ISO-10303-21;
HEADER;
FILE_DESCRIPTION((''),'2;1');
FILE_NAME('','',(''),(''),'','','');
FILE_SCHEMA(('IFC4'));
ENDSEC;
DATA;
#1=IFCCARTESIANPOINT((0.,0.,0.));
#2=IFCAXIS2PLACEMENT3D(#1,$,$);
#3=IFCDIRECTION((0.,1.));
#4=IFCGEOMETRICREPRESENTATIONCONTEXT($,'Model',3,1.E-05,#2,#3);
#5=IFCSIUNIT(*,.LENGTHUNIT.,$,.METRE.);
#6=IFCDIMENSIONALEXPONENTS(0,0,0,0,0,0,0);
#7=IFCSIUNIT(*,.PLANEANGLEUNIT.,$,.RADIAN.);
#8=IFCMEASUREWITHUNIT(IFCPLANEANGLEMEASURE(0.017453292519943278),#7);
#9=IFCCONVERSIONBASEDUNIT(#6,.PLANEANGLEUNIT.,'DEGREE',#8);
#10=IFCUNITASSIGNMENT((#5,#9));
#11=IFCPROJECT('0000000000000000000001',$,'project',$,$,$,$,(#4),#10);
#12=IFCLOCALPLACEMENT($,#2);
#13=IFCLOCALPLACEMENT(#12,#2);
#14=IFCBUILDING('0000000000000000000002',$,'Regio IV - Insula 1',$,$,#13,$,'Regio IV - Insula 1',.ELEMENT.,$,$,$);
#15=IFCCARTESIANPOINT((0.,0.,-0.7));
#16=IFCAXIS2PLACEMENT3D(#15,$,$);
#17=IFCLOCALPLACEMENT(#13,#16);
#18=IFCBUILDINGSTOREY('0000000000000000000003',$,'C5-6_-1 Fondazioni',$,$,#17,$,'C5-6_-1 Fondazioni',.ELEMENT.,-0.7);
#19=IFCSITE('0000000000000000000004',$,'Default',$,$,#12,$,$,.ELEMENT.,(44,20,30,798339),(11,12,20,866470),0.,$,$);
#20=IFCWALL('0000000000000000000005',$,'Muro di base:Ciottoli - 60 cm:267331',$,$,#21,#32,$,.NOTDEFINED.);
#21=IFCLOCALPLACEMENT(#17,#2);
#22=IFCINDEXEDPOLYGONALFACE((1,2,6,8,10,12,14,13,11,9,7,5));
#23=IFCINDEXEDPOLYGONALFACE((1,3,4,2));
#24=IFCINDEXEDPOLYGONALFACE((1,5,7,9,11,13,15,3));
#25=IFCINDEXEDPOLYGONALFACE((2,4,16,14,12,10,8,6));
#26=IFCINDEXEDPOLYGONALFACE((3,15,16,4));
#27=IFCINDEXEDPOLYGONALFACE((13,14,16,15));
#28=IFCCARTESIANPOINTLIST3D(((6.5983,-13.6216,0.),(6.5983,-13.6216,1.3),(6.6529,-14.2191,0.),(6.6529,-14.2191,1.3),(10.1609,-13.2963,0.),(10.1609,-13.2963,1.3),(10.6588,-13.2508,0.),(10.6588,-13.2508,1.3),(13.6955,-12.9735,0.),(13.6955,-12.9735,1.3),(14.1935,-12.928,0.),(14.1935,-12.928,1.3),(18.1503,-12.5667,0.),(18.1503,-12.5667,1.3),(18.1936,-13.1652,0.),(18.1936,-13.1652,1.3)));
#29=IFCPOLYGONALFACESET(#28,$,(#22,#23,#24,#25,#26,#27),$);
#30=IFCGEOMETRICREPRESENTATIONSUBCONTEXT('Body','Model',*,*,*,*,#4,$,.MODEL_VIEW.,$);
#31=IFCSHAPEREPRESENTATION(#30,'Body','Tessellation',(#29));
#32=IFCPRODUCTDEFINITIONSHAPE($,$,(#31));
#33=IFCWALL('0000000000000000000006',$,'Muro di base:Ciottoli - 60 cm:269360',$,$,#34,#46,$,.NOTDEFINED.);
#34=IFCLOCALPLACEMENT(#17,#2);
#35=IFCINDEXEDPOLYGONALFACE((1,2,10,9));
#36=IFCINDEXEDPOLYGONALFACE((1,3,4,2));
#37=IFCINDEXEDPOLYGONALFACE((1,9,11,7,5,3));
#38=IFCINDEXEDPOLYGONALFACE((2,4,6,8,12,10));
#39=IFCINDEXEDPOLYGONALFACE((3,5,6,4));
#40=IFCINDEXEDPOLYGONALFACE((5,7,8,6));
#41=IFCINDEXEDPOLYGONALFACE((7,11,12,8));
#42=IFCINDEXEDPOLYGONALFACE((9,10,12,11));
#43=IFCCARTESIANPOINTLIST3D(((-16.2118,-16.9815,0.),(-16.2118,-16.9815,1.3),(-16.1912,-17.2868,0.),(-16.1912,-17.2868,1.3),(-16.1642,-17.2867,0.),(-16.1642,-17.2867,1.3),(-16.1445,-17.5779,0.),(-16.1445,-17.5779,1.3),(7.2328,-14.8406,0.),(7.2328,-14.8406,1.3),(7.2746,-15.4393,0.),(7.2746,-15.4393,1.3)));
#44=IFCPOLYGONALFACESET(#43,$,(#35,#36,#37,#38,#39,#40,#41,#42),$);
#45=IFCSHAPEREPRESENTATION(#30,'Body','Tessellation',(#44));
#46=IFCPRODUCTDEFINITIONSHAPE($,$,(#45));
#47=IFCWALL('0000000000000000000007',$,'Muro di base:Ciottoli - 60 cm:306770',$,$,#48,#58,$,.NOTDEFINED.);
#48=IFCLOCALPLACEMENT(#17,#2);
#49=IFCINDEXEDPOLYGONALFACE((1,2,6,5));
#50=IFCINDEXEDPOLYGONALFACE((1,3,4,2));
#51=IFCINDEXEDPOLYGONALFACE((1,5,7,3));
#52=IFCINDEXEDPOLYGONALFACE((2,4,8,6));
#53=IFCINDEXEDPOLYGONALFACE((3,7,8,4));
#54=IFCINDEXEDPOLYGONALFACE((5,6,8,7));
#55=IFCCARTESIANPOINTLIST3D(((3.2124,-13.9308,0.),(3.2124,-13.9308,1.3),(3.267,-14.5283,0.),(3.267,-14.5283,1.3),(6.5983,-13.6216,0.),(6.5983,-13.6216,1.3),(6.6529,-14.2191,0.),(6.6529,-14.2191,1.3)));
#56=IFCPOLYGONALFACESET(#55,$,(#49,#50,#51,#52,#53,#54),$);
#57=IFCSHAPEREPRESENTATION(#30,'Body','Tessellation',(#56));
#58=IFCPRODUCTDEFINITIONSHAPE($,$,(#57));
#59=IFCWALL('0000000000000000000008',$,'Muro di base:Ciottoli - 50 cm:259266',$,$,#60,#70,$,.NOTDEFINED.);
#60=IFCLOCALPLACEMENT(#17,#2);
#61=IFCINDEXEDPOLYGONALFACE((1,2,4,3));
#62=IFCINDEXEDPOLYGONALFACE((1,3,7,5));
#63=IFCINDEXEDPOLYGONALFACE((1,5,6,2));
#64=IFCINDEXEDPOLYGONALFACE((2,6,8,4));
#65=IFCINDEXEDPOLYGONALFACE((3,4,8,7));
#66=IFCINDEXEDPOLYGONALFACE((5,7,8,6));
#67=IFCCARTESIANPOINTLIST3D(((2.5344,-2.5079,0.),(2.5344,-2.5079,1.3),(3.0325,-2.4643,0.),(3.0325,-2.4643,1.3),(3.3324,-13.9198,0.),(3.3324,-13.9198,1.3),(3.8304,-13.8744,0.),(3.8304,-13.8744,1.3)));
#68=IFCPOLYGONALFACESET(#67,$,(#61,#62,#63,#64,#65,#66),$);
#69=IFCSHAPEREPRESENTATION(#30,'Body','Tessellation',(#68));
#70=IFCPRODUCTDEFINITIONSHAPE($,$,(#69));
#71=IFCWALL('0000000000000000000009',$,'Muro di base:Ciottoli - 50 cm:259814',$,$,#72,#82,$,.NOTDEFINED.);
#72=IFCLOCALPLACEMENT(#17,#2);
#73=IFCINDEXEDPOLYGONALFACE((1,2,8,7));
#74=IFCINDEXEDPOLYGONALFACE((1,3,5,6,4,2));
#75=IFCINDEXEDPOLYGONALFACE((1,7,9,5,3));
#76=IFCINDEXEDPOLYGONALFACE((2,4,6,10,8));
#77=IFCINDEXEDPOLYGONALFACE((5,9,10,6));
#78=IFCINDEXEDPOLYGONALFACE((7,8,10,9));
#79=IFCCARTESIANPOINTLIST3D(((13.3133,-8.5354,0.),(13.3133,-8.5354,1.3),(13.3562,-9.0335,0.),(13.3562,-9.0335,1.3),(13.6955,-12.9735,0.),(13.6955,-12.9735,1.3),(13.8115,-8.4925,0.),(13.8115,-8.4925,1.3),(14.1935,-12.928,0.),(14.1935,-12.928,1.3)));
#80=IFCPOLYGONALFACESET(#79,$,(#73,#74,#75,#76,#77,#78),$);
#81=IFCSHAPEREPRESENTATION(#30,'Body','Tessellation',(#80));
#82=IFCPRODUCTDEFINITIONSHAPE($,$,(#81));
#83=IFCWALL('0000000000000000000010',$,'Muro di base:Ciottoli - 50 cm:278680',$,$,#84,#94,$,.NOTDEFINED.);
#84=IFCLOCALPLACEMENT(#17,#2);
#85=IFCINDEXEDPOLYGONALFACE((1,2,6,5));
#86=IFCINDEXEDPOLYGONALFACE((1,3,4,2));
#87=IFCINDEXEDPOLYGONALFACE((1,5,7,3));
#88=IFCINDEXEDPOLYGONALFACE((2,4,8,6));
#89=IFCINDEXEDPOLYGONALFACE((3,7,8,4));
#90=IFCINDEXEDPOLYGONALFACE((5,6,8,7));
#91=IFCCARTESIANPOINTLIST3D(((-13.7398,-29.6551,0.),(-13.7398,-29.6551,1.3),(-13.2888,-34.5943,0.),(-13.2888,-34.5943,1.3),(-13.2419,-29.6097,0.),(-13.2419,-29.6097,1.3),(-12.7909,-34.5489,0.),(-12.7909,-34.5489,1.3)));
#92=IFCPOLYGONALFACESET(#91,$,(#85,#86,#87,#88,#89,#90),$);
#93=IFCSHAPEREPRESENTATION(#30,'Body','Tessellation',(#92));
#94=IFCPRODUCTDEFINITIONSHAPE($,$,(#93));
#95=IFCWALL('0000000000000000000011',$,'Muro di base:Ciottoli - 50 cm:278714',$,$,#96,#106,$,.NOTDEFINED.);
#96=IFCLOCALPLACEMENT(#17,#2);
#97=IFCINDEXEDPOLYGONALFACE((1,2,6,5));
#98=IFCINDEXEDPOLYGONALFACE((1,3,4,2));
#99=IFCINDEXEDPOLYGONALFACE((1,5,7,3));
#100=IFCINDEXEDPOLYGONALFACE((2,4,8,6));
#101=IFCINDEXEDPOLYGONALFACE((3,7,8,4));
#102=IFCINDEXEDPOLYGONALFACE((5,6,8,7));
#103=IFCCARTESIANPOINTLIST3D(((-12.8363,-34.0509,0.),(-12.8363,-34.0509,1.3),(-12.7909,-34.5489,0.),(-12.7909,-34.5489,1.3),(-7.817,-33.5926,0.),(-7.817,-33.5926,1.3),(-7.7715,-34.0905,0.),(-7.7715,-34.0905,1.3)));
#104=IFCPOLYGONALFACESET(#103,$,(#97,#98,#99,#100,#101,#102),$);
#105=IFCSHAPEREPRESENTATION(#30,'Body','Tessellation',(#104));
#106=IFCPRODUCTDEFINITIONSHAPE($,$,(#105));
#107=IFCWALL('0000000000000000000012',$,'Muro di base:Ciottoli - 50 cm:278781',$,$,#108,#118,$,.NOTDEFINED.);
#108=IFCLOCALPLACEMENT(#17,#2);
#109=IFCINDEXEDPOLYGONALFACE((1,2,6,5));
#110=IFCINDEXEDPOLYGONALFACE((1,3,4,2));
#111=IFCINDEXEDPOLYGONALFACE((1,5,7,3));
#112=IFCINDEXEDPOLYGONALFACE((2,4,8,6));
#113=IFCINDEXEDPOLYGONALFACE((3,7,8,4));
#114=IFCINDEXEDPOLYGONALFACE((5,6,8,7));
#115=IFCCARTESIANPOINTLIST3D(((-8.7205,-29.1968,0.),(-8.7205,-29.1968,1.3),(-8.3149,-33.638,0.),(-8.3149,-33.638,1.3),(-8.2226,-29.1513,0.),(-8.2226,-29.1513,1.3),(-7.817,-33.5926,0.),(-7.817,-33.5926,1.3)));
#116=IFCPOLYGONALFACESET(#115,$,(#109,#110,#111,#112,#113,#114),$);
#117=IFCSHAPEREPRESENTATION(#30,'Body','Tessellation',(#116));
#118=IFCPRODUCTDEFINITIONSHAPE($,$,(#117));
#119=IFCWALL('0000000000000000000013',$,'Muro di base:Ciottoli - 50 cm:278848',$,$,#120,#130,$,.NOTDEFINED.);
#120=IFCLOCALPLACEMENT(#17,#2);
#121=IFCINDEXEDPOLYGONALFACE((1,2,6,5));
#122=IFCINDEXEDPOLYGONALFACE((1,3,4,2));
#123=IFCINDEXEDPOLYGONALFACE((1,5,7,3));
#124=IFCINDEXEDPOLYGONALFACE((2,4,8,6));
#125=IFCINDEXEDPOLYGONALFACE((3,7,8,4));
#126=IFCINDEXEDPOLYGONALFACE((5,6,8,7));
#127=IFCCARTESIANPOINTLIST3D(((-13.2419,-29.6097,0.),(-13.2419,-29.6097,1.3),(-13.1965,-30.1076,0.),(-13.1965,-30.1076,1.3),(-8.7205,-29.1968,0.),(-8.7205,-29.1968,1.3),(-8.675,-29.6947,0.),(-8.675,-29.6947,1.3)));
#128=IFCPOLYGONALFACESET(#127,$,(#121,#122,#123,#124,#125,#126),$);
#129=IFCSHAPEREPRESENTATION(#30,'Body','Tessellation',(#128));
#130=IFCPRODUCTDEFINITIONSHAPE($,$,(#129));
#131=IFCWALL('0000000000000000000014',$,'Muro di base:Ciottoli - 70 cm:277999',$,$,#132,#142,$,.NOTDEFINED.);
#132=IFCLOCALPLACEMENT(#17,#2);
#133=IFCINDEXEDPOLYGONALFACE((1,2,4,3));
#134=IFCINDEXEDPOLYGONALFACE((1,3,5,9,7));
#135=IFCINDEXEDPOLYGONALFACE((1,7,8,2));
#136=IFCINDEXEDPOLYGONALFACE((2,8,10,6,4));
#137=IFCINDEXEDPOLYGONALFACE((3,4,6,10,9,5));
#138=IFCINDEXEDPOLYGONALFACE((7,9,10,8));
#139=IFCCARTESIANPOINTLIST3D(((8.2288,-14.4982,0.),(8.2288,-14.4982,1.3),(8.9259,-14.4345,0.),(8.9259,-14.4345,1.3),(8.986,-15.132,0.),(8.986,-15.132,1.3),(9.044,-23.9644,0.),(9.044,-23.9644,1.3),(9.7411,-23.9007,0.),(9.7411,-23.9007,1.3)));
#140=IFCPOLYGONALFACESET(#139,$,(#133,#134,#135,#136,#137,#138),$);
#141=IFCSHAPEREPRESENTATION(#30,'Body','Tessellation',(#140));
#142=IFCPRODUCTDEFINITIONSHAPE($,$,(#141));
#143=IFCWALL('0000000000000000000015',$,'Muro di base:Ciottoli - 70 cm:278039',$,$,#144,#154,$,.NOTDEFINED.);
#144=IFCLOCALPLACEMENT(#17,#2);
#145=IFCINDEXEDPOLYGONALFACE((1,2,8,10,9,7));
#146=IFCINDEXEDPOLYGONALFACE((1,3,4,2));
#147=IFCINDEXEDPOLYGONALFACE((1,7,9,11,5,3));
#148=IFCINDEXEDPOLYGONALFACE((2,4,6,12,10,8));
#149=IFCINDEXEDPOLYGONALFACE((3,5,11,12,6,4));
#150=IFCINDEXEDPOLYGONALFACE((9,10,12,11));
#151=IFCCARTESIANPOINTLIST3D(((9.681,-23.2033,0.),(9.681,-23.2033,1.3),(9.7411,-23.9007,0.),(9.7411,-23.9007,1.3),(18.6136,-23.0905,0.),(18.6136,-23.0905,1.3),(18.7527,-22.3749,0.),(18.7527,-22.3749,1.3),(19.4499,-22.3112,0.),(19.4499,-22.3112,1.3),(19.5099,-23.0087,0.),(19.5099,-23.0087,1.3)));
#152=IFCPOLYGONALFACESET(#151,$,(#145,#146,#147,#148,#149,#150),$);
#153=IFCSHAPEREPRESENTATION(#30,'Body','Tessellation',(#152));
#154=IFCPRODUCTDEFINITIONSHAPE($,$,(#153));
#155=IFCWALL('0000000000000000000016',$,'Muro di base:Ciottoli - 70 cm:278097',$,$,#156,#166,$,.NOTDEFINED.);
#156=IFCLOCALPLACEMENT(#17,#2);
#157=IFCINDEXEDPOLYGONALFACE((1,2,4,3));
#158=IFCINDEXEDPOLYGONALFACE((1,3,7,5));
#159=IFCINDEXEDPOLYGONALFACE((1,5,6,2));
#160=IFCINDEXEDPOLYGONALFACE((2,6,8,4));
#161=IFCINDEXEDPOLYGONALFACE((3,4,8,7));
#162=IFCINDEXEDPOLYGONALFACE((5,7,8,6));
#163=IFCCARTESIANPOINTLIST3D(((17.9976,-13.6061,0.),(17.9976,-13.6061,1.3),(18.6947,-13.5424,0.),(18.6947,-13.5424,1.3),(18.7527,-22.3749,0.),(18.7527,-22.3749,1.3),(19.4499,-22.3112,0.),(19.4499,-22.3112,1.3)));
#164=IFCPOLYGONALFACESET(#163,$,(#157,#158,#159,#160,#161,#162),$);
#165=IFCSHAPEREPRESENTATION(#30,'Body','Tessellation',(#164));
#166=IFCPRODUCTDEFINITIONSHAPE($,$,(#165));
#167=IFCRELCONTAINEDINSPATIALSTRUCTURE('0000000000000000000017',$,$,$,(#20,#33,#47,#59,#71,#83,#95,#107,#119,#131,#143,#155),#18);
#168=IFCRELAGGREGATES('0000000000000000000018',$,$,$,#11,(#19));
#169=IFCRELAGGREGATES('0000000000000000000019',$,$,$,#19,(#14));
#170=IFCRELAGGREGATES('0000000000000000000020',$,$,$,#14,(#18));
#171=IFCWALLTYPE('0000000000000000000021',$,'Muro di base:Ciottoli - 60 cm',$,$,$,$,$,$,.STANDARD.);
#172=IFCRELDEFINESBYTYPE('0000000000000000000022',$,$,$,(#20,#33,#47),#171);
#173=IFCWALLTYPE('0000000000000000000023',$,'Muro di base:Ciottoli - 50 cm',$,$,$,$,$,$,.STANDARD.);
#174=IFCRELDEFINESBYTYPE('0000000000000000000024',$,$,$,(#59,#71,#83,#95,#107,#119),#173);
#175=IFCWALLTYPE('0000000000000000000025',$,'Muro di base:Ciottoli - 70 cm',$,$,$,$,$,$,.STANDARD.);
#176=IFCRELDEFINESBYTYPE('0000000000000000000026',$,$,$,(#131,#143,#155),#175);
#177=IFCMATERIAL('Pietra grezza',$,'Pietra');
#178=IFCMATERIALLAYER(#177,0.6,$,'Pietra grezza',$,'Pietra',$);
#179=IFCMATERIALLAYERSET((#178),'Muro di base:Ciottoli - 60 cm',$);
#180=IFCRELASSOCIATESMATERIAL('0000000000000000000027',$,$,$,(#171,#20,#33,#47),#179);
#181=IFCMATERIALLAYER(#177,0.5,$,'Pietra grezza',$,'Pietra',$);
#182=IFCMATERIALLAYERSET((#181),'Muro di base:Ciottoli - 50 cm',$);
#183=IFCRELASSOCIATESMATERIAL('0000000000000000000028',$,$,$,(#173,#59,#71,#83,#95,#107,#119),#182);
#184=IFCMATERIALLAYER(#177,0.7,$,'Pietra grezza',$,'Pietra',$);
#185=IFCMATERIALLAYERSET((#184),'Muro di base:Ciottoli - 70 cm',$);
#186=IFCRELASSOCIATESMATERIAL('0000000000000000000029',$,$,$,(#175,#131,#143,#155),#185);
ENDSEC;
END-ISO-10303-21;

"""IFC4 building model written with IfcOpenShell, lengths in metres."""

from ifc_helpers import new_model, entity, si_unit, converted_unit, direction, frame, frame_2d, origin, place, context, subcontext, project, spatial, polyline, rectangle, outline, extrude, material, layer, layer_set, layer_usage, type_object, element, save


model = new_model("IFC4")

# Units and contexts
model_context = context("Model", 3, precision=1e-05, world=origin(), true_north=direction((0.0, 1.0)))
body_context = subcontext(model_context, "Body", "Model", "MODEL_VIEW")
ifc_project = project(units=[si_unit("LENGTHUNIT", "METRE"), converted_unit("PLANEANGLEUNIT", "DEGREE", entity("IfcPlaneAngleMeasure", 0.017453292519943278), si_unit("PLANEANGLEUNIT", "RADIAN"), dimensions=[0, 0, 0, 0, 0, 0, 0])], contexts=[model_context])

# Site, building, storey
site_placement = place(None, origin())
site = spatial("IfcSite", under=ifc_project, at=site_placement, Name="Default", CompositionType="ELEMENT", RefLatitude=(44, 20, 30, 798339), RefLongitude=(11, 12, 20, 866470), RefElevation=0.0)
building_placement = place(site_placement, origin())
building = spatial("IfcBuilding", under=site, at=building_placement, Name="Regio IV - Insula 1", LongName="Regio IV - Insula 1", CompositionType="ELEMENT")
storey_placement = place(building_placement, frame((0.0, 0.0, -0.7)))
storey = spatial("IfcBuildingStorey", under=building, at=storey_placement, Name="C5-6_-1 Fondazioni", LongName="C5-6_-1 Fondazioni", CompositionType="ELEMENT", Elevation=-0.7)

# Walls
ifc_material = material(Name="Pietra grezza", Category="Pietra")
ifc_layer_1 = layer(ifc_material, 0.6, Name="Pietra grezza", Category="Pietra")
ifc_layer_set_1 = layer_set([ifc_layer_1], Name="Muro di base:Ciottoli - 60 cm")
ifc_layer_usage_1 = layer_usage(ifc_layer_set_1, "AXIS2", "NEGATIVE", 0.3)
wall_type_1 = type_object("IfcWallType", Name="Muro di base:Ciottoli - 60 cm", PredefinedType="STANDARD", material=ifc_layer_set_1)
wall_1_placement = place(storey_placement, frame((6.6256, -13.9203, 0.0), z_axis=(0.0, 0.0, 1.0), x_axis=(0.995856, 0.090941, 0.0)))
element("IfcWall", 1, at=wall_1_placement, inside=storey, type_object=wall_type_1, material=ifc_layer_usage_1, Name="Muro di base:Ciottoli - 60 cm:267331", PredefinedType="NOTDEFINED", context=body_context, shape_type="SweptSolid", body=[
    extrude(outline(polyline([(11.5887, -0.3), (11.6, 0.3), (7.6267, 0.3), (7.1267, 0.3), (4.0774, 0.3), (3.5774, 0.3), (0.0, 0.3), (0.0, -0.3), (11.5887, -0.3)])), origin(), (0.0, 0.0, 1.0), 1.3),
])
ifc_layer_usage_2 = layer_usage(ifc_layer_set_1, "AXIS2", "NEGATIVE", 0.3)
wall_2_placement = place(storey_placement, frame((-16.1845, -17.2803, 0.0), z_axis=(0.0, 0.0, 1.0), x_axis=(0.995856, 0.090941, 0.0)))
element("IfcWall", 2, at=wall_2_placement, inside=storey, type_object=wall_type_1, material=ifc_layer_usage_2, Name="Muro di base:Ciottoli - 60 cm:269360", PredefinedType="NOTDEFINED", context=body_context, shape_type="SweptSolid", body=[
    extrude(outline(polyline([(23.5294, -0.3), (23.5421, 0.3), (0.0, 0.3), (-0.0072, -0.0059), (0.0197, -0.0082), (0.0128, -0.3), (23.5294, -0.3)])), origin(), (0.0, 0.0, 1.0), 1.3),
])
ifc_layer_usage_3 = layer_usage(ifc_layer_set_1, "AXIS2", "NEGATIVE", 0.3)
wall_3_placement = place(storey_placement, frame((3.2397, -14.2295, 0.0), z_axis=(0.0, 0.0, 1.0), x_axis=(0.995856, 0.090941, 0.0)))
element("IfcWall", 3, at=wall_3_placement, inside=storey, type_object=wall_type_1, material=ifc_layer_usage_3, Name="Muro di base:Ciottoli - 60 cm:306770", PredefinedType="NOTDEFINED", context=body_context, shape_type="SweptSolid", body=[
    extrude(rectangle(XDim=3.4, YDim=0.6, at=frame_2d((1.7, 0.0), x_axis=(-1.0, 0.0))), origin(), (0.0, 0.0, 1.0), 1.3),
])
ifc_layer_2 = layer(ifc_material, 0.5, Name="Pietra grezza", Category="Pietra")
ifc_layer_set_2 = layer_set([ifc_layer_2], Name="Muro di base:Ciottoli - 50 cm")
ifc_layer_usage_4 = layer_usage(ifc_layer_set_2, "AXIS2", "NEGATIVE", 0.25)
wall_type_2 = type_object("IfcWallType", Name="Muro di base:Ciottoli - 50 cm", PredefinedType="STANDARD", material=ifc_layer_set_2)
wall_4_placement = place(storey_placement, frame((3.5818, -13.9024, 0.0), z_axis=(0.0, 0.0, 1.0), x_axis=(-0.069756, 0.997564, 0.0)))
element("IfcWall", 4, at=wall_4_placement, inside=storey, type_object=wall_type_2, material=ifc_layer_usage_4, Name="Muro di base:Ciottoli - 50 cm:259266", PredefinedType="NOTDEFINED", context=body_context, shape_type="SweptSolid", body=[
    extrude(outline(polyline([(11.4486, -0.25), (11.4398, 0.25), (0.0, 0.25), (0.0106, -0.25), (11.4486, -0.25)])), origin(), (0.0, 0.0, 1.0), 1.3),
])
ifc_layer_usage_5 = layer_usage(ifc_layer_set_2, "AXIS2", "NEGATIVE", 0.25)
wall_5_placement = place(storey_placement, frame((13.9446, -12.952, 0.0), z_axis=(0.0, 0.0, 1.0), x_axis=(-0.085801, 0.996312, 0.0)))
element("IfcWall", 5, at=wall_5_placement, inside=storey, type_object=wall_type_2, material=ifc_layer_usage_5, Name="Muro di base:Ciottoli - 50 cm:259814", PredefinedType="NOTDEFINED", context=body_context, shape_type="SweptSolid", body=[
    extrude(outline(polyline([(4.4545, -0.25), (4.4545, 0.25), (3.9545, 0.25), (0.0, 0.25), (0.0026, -0.25), (4.4545, -0.25)])), origin(), (0.0, 0.0, 1.0), 1.3),
])
ifc_layer_usage_6 = layer_usage(ifc_layer_set_2, "AXIS2", "NEGATIVE", 0.25)
wall_6_placement = place(storey_placement, frame((-13.4909, -29.6324, 0.0), z_axis=(0.0, 0.0, 1.0), x_axis=(0.090941, -0.995856, 0.0)))
element("IfcWall", 6, at=wall_6_placement, inside=storey, type_object=wall_type_2, material=ifc_layer_usage_6, Name="Muro di base:Ciottoli - 50 cm:278680", PredefinedType="NOTDEFINED", context=body_context, shape_type="SweptSolid", body=[
    extrude(rectangle(XDim=4.9598, YDim=0.5, at=frame_2d((2.4799, 0.0), x_axis=(-1.0, 0.0))), origin(), (0.0, 0.0, 1.0), 1.3),
])
ifc_layer_usage_7 = layer_usage(ifc_layer_set_2, "AXIS2", "NEGATIVE", 0.25)
wall_7_placement = place(storey_placement, frame((-12.8136, -34.2999, 0.0), z_axis=(0.0, 0.0, 1.0), x_axis=(0.995856, 0.090941, 0.0)))
element("IfcWall", 7, at=wall_7_placement, inside=storey, type_object=wall_type_2, material=ifc_layer_usage_7, Name="Muro di base:Ciottoli - 50 cm:278714", PredefinedType="NOTDEFINED", context=body_context, shape_type="SweptSolid", body=[
    extrude(rectangle(XDim=5.0402, YDim=0.5, at=frame_2d((2.5201, 0.0), x_axis=(-1.0, 0.0))), origin(), (0.0, 0.0, 1.0), 1.3),
])
ifc_layer_usage_8 = layer_usage(ifc_layer_set_2, "AXIS2", "NEGATIVE", 0.25)
wall_8_placement = place(storey_placement, frame((-8.0659, -33.6153, 0.0), z_axis=(0.0, 0.0, 1.0), x_axis=(-0.090941, 0.995856, 0.0)))
element("IfcWall", 8, at=wall_8_placement, inside=storey, type_object=wall_type_2, material=ifc_layer_usage_8, Name="Muro di base:Ciottoli - 50 cm:278781", PredefinedType="NOTDEFINED", context=body_context, shape_type="SweptSolid", body=[
    extrude(rectangle(XDim=4.4598, YDim=0.5, at=frame_2d((2.2299, 0.0), x_axis=(-1.0, 0.0))), origin(), (0.0, 0.0, 1.0), 1.3),
])
ifc_layer_usage_9 = layer_usage(ifc_layer_set_2, "AXIS2", "NEGATIVE", 0.25)
wall_9_placement = place(storey_placement, frame((-8.6978, -29.4457, 0.0), z_axis=(0.0, 0.0, 1.0), x_axis=(-0.995856, -0.090941, 0.0)))
element("IfcWall", 9, at=wall_9_placement, inside=storey, type_object=wall_type_2, material=ifc_layer_usage_9, Name="Muro di base:Ciottoli - 50 cm:278848", PredefinedType="NOTDEFINED", context=body_context, shape_type="SweptSolid", body=[
    extrude(rectangle(XDim=4.5402, YDim=0.5, at=frame_2d((2.2701, 0.0), x_axis=(-1.0, 0.0))), origin(), (0.0, 0.0, 1.0), 1.3),
])
ifc_layer_3 = layer(ifc_material, 0.7, Name="Pietra grezza", Category="Pietra")
ifc_layer_set_3 = layer_set([ifc_layer_3], Name="Muro di base:Ciottoli - 70 cm")
ifc_layer_usage_10 = layer_usage(ifc_layer_set_3, "AXIS2", "NEGATIVE", 0.35)
wall_type_3 = type_object("IfcWallType", Name="Muro di base:Ciottoli - 70 cm", PredefinedType="STANDARD", material=ifc_layer_set_3)
wall_10_placement = place(storey_placement, frame((8.5772, -14.4646, 0.0), z_axis=(0.0, 0.0, 1.0), x_axis=(0.085801, -0.996312, 0.0)))
element("IfcWall", 10, at=wall_10_placement, inside=storey, type_object=wall_type_3, material=ifc_layer_usage_10, Name="Muro di base:Ciottoli - 70 cm:277999", PredefinedType="NOTDEFINED", context=body_context, shape_type="SweptSolid", body=[
    extrude(outline(polyline([(9.5049, -0.35), (9.5012, 0.35), (0.7, 0.35), (0.0, 0.35), (0.0036, -0.35), (9.5049, -0.35)])), origin(), (0.0, 0.0, 1.0), 1.3),
])
ifc_layer_usage_11 = layer_usage(ifc_layer_set_3, "AXIS2", "NEGATIVE", 0.35)
wall_11_placement = place(storey_placement, frame((9.7093, -23.5522, 0.0), z_axis=(0.0, 0.0, 1.0), x_axis=(0.995856, 0.090941, 0.0)))
element("IfcWall", 11, at=wall_11_placement, inside=storey, type_object=wall_type_3, material=ifc_layer_usage_11, Name="Muro di base:Ciottoli - 70 cm:278039", PredefinedType="NOTDEFINED", context=body_context, shape_type="SweptSolid", body=[
    extrude(outline(polyline([(9.8095, -0.35), (9.8131, 0.35), (9.1131, 0.35), (0.0036, 0.35), (0.0, -0.35), (8.9095, -0.35), (9.8095, -0.35)])), origin(), (0.0, 0.0, 1.0), 1.3),
])
ifc_layer_usage_12 = layer_usage(ifc_layer_set_3, "AXIS2", "NEGATIVE", 0.35)
wall_12_placement = place(storey_placement, frame((19.1015, -22.3449, 0.0), z_axis=(0.0, 0.0, 1.0), x_axis=(-0.085801, 0.996312, 0.0)))
element("IfcWall", 12, at=wall_12_placement, inside=storey, type_object=wall_type_3, material=ifc_layer_usage_12, Name="Muro di base:Ciottoli - 70 cm:278097", PredefinedType="NOTDEFINED", context=body_context, shape_type="SweptSolid", body=[
    extrude(outline(polyline([(8.8049, -0.35), (8.8012, 0.35), (0.0, 0.35), (0.0036, -0.35), (8.8049, -0.35)])), origin(), (0.0, 0.0, 1.0), 1.3),
])

save(model, "model.ifc")
